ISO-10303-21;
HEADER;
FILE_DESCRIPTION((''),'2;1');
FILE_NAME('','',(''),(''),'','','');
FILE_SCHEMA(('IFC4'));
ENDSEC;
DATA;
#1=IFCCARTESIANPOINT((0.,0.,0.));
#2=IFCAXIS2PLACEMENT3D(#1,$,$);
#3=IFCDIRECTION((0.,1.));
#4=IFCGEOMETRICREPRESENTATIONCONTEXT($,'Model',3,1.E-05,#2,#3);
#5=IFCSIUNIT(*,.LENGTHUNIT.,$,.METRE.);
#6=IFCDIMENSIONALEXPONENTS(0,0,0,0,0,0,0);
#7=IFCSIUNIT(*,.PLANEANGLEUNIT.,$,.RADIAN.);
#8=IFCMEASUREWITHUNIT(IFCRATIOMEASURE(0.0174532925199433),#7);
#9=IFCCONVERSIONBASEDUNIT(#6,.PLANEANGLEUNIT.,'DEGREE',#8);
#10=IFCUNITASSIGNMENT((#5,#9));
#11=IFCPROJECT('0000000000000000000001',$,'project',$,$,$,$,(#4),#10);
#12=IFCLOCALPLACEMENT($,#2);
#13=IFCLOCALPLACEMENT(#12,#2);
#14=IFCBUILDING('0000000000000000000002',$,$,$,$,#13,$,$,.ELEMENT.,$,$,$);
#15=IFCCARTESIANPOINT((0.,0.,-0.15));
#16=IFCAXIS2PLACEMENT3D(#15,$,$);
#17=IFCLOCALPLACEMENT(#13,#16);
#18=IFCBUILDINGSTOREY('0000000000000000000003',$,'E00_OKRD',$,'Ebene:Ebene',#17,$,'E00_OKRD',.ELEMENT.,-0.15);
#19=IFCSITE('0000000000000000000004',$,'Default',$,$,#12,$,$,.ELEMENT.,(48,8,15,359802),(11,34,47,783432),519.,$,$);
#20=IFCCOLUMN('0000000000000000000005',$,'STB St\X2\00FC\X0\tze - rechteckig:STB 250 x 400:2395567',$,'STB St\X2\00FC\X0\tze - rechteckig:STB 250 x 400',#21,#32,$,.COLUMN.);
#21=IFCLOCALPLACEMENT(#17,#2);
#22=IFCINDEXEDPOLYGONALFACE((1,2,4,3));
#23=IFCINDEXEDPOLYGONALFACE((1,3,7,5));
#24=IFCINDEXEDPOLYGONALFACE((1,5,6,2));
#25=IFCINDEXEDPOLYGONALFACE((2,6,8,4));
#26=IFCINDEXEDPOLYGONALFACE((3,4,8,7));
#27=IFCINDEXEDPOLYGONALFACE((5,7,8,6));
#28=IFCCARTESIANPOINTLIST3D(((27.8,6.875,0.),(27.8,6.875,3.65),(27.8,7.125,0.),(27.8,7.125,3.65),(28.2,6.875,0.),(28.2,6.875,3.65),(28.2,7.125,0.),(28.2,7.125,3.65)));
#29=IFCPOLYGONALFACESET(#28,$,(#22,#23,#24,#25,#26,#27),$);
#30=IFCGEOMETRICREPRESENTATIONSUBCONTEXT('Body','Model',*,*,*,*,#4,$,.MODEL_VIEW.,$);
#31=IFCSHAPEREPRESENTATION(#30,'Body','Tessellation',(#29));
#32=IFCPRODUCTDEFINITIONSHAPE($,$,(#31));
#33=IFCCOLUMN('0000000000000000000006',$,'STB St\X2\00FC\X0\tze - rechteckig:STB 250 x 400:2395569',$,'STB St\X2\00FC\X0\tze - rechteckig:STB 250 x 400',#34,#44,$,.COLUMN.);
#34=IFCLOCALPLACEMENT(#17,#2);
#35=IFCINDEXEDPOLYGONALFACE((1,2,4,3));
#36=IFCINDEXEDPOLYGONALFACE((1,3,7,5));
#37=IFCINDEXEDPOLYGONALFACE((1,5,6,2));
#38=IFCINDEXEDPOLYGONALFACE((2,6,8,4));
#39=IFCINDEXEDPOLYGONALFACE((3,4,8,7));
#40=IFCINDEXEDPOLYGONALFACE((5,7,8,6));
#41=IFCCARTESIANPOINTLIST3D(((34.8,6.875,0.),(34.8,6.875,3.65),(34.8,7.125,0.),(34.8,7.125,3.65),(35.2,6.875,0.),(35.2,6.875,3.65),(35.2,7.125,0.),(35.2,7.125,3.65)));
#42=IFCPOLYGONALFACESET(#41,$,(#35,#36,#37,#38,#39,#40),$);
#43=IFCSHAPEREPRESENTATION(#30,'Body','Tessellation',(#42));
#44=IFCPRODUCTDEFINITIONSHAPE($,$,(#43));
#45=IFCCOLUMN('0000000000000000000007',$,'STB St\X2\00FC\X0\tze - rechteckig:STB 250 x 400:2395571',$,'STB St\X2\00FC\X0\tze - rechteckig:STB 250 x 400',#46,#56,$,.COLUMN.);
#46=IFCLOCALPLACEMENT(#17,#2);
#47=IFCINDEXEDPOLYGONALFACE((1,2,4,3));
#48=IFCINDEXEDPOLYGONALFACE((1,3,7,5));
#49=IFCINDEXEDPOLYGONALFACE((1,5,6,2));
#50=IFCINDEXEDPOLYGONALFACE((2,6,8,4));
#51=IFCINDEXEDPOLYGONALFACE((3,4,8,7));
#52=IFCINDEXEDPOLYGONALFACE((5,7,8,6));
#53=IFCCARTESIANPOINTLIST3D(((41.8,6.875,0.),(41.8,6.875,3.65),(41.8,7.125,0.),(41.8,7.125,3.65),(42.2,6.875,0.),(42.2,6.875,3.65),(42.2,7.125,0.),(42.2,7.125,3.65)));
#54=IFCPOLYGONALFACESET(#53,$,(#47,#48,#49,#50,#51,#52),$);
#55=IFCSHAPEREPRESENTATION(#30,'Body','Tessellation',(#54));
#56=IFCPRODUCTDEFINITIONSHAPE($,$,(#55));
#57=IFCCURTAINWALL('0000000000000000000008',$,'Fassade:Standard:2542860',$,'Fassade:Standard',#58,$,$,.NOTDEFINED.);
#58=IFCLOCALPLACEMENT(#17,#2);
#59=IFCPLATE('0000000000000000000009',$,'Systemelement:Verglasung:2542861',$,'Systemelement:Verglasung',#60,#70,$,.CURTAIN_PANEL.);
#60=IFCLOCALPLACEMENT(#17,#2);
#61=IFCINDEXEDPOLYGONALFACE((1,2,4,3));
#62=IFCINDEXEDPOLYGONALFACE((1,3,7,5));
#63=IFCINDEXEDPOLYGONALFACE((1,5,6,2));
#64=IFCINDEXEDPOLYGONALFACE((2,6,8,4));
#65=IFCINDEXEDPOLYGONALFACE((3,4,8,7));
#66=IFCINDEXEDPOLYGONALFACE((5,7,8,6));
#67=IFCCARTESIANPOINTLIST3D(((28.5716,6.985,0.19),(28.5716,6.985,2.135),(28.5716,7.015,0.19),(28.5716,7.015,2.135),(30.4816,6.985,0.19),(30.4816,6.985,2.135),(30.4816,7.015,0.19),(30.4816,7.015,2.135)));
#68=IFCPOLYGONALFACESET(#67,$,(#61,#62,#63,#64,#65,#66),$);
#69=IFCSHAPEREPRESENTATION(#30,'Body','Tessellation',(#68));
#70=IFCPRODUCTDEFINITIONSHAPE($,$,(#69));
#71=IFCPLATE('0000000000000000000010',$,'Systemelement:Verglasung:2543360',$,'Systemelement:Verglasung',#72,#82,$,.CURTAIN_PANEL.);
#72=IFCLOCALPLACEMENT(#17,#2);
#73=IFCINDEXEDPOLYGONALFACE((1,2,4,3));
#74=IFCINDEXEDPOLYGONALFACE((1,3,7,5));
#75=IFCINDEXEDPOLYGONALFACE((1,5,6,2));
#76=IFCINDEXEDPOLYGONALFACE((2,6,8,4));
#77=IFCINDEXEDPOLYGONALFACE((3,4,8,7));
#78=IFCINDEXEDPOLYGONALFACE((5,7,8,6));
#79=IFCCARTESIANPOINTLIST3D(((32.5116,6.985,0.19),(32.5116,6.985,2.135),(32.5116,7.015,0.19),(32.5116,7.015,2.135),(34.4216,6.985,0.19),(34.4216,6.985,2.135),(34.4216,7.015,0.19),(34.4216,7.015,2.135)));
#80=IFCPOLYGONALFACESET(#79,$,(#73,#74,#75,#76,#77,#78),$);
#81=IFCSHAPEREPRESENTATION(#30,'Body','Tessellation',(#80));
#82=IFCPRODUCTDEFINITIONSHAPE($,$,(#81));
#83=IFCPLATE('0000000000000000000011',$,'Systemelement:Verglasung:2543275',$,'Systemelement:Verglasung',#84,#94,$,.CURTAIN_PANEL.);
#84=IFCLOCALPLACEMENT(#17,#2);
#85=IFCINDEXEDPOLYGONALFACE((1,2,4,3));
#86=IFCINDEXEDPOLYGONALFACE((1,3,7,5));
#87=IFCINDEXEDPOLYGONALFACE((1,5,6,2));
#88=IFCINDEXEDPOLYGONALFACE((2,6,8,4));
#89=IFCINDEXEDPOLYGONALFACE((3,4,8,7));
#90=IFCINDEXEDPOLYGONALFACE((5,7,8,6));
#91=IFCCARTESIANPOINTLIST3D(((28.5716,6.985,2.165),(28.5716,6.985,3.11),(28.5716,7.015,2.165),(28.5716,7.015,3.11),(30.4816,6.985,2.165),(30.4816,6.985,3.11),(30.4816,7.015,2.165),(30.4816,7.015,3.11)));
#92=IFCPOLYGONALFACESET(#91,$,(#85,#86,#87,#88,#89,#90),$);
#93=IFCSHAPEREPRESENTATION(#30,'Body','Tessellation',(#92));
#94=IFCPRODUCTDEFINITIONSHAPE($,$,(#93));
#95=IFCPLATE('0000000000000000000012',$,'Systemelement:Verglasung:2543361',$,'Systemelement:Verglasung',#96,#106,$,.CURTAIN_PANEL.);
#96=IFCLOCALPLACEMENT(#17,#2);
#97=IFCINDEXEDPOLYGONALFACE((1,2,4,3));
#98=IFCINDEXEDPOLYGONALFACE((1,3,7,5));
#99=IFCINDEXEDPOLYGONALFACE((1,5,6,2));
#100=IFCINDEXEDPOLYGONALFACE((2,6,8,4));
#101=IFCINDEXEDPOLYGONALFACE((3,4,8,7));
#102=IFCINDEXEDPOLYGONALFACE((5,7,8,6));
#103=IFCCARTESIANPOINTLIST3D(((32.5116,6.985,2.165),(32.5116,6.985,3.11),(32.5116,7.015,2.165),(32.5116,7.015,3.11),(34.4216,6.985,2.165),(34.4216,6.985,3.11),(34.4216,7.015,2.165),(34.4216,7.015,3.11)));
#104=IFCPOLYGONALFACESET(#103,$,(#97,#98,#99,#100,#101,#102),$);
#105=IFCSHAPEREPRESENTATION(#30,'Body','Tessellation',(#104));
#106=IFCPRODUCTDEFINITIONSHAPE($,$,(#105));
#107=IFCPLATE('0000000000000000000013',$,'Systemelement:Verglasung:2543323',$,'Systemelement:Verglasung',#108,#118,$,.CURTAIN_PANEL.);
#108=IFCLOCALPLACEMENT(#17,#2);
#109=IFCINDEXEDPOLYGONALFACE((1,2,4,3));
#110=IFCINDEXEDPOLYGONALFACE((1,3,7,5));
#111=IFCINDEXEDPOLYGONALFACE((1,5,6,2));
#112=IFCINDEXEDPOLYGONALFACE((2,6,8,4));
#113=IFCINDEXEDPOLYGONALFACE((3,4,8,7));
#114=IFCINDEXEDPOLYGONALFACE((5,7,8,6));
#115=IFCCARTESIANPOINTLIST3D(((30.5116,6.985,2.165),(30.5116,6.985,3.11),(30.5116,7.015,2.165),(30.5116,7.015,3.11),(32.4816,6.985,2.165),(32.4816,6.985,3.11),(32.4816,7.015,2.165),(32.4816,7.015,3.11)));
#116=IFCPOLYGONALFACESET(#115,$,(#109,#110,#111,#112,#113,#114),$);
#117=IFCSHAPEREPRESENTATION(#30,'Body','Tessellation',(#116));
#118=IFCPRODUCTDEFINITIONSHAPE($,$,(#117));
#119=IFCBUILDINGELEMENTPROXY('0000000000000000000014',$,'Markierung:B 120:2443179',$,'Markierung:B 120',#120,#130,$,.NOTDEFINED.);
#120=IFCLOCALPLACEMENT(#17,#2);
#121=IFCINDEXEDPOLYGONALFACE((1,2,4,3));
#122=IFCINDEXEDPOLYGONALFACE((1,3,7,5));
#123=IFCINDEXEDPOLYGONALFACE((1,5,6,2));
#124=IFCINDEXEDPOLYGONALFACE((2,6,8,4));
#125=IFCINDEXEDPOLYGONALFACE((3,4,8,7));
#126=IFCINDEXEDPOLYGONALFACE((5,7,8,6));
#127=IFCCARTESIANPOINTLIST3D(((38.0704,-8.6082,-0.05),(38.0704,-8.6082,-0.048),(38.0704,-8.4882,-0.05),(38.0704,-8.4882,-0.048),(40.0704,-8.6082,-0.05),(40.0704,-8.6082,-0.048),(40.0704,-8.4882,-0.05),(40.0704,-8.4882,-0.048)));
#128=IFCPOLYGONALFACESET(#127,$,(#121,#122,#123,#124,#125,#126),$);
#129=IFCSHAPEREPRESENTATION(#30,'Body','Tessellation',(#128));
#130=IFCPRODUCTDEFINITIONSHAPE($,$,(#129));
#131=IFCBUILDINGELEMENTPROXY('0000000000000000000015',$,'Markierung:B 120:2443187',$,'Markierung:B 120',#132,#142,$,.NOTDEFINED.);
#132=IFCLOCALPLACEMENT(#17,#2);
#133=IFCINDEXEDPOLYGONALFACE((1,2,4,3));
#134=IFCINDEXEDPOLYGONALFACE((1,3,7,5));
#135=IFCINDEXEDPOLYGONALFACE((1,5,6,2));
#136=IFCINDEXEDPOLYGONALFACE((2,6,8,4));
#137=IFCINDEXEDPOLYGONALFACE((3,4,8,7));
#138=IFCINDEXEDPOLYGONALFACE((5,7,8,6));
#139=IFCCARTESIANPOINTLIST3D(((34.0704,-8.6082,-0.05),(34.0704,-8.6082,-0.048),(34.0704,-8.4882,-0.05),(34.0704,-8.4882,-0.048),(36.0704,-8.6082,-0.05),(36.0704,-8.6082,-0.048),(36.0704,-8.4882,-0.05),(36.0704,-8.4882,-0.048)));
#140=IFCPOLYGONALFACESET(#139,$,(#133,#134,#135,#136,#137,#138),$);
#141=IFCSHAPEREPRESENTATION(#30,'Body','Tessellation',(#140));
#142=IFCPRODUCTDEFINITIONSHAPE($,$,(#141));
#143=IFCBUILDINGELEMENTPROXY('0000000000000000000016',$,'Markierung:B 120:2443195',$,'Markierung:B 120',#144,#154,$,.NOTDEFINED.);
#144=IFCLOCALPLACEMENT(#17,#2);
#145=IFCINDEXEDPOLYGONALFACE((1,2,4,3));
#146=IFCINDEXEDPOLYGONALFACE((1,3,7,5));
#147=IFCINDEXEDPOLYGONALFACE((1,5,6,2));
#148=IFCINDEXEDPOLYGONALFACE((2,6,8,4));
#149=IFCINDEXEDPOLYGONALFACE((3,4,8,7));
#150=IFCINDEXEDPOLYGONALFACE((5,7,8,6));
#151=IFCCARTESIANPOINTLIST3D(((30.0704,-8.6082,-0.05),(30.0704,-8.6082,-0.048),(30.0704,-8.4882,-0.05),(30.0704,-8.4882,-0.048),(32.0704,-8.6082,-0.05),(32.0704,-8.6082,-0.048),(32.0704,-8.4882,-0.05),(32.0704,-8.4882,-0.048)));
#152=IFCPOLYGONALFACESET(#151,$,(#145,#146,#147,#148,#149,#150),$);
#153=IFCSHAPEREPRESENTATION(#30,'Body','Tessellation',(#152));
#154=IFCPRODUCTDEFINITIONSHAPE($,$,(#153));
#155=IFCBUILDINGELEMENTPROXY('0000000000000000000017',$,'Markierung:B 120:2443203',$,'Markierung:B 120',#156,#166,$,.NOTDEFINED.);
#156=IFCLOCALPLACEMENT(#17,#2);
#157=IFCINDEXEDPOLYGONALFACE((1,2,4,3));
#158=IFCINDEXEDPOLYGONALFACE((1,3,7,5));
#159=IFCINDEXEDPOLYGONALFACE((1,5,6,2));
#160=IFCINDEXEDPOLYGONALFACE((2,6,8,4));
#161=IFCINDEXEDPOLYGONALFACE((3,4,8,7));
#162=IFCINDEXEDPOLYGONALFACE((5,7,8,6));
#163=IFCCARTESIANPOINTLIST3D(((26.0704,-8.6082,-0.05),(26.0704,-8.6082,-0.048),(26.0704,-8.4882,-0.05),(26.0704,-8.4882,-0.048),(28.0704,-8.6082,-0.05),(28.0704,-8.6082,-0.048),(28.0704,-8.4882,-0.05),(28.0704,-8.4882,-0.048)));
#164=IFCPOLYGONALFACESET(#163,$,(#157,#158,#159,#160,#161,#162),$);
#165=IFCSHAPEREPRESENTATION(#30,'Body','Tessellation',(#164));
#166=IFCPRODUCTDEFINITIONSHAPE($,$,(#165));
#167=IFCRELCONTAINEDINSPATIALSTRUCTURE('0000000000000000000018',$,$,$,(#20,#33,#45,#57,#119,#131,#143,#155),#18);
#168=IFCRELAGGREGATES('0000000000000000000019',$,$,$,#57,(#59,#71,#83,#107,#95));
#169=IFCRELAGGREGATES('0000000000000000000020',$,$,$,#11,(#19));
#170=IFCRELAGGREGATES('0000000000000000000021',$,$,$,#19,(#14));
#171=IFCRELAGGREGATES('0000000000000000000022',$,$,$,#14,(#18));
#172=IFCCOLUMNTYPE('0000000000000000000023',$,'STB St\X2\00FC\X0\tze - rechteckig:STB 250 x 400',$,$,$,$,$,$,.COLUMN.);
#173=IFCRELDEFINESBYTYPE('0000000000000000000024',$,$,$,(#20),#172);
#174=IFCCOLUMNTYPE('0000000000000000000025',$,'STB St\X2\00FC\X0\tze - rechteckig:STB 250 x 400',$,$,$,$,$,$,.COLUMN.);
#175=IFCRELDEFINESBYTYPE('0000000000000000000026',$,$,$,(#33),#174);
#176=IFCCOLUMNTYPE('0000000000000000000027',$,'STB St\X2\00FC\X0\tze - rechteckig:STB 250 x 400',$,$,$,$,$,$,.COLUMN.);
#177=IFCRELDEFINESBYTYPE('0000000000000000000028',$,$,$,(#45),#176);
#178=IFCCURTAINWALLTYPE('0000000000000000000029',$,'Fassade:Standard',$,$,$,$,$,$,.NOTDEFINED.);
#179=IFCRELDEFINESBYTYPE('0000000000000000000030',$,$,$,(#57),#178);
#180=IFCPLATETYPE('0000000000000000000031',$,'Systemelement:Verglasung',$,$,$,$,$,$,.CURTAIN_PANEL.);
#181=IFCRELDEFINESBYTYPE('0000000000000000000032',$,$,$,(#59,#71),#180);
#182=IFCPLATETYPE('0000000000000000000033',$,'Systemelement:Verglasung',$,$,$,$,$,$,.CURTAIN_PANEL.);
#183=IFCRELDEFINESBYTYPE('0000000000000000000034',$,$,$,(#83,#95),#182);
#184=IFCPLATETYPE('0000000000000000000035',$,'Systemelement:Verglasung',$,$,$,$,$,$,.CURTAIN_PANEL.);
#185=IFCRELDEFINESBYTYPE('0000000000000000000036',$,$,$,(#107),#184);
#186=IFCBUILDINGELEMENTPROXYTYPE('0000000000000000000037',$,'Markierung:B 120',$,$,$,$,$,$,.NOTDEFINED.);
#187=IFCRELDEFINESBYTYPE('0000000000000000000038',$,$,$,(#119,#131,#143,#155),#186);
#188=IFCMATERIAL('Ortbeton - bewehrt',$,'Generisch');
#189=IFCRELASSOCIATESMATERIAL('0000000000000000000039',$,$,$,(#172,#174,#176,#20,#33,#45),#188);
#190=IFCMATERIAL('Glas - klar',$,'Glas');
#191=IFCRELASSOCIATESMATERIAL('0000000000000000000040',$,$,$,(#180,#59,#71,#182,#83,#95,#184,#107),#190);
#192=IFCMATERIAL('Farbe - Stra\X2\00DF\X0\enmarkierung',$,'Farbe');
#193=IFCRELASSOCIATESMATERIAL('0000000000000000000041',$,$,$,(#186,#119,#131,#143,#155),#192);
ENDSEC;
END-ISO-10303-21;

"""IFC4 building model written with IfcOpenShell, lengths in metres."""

from ifc_helpers import new_model, entity, si_unit, converted_unit, direction, frame, frame_2d, origin, origin_2d_with_axis, place, context, subcontext, project, spatial, rectangle, extrude, shape, source, transform, mapped, material, material_profile, profile_set, profile_usage, type_object, type_shapes, element, aggregate, save


model = new_model("IFC4")

# Units and contexts
model_context = context("Model", 3, precision=1e-05, world=origin(), true_north=direction((0.0, 1.0)))
body_context = subcontext(model_context, "Body", "Model", "MODEL_VIEW")
footprint_context = subcontext(model_context, "FootPrint", "Model", "MODEL_VIEW")
ifc_project = project(units=[si_unit("LENGTHUNIT", "METRE"), converted_unit("PLANEANGLEUNIT", "DEGREE", entity("IfcRatioMeasure", 0.0174532925199433), si_unit("PLANEANGLEUNIT", "RADIAN"), dimensions=[0, 0, 0, 0, 0, 0, 0])], contexts=[model_context])

# Site, building, storey
site_placement = place(None, frame((0.0, 0.0, 0.0)))
site = spatial("IfcSite", under=ifc_project, at=site_placement, Name="Default", CompositionType="ELEMENT", RefLatitude=(48, 8, 15, 359802), RefLongitude=(11, 34, 47, 783432), RefElevation=519.0)
building_placement = place(site_placement, origin())
building = spatial("IfcBuilding", under=site, at=building_placement, CompositionType="ELEMENT")
storey_placement = place(building_placement, frame((0.0, 0.0, -0.15)))
storey = spatial("IfcBuildingStorey", under=building, at=storey_placement, Name="E00_OKRD", ObjectType="Ebene:Ebene", LongName="E00_OKRD", CompositionType="ELEMENT", Elevation=-0.15)

# Columns
ifc_material_1 = material(Name="Ortbeton - bewehrt", Category="Generisch")
ifc_material_profile_1 = material_profile(ifc_material_1, rectangle(XDim=0.4, YDim=0.25, at=frame_2d((0.0, 0.0), x_axis=(1.0, 0.0))), Name="STB 250 x 400")
ifc_profile_set_1 = profile_set([ifc_material_profile_1], Name="STB 250 x 400")
ifc_profile_usage_1 = profile_usage(ifc_profile_set_1)
column_type_1 = type_object("IfcColumnType", Name="STB Stütze - rechteckig:STB 250 x 400", PredefinedType="COLUMN", material=ifc_profile_set_1)
shared_shape_1 = source(origin(), body_context, "Body", "SweptSolid", [
    extrude(rectangle(XDim=0.4, YDim=0.25, at=frame_2d((0.0, 0.0), x_axis=(1.0, 0.0))), frame((0.2, 0.125, 0.0), z_axis=(0.0, 0.0, 1.0), x_axis=(-1.0, 0.0, 0.0)), (0.0, 0.0, 1.0), 3.65),
])
type_shapes(column_type_1, [shared_shape_1])
column_1_placement = place(storey_placement, frame((27.8, 6.875, 0.0)))
element("IfcColumn", 1, at=column_1_placement, inside=storey, type_object=column_type_1, material=ifc_profile_usage_1, Name="STB Stütze - rechteckig:STB 250 x 400:2395567", ObjectType="STB Stütze - rechteckig:STB 250 x 400", PredefinedType="COLUMN", context=body_context, shape_type="MappedRepresentation", body=[
    mapped(shared_shape_1, transform((0.0, 0.0, 0.0), scale=1.0)),
])
ifc_profile_usage_2 = profile_usage(ifc_profile_set_1)
column_type_2 = type_object("IfcColumnType", Name="STB Stütze - rechteckig:STB 250 x 400", PredefinedType="COLUMN", material=ifc_profile_set_1)
shared_shape_2 = source(origin(), body_context, "Body", "SweptSolid", [
    extrude(rectangle(XDim=0.4, YDim=0.25, at=frame_2d((0.0, 0.0), x_axis=(1.0, 0.0))), frame((0.2, 0.125, 0.0), z_axis=(0.0, 0.0, 1.0), x_axis=(-1.0, 0.0, 0.0)), (0.0, 0.0, 1.0), 3.65),
])
type_shapes(column_type_2, [shared_shape_2])
column_2_placement = place(storey_placement, frame((34.8, 6.875, 0.0)))
element("IfcColumn", 2, at=column_2_placement, inside=storey, type_object=column_type_2, material=ifc_profile_usage_2, Name="STB Stütze - rechteckig:STB 250 x 400:2395569", ObjectType="STB Stütze - rechteckig:STB 250 x 400", PredefinedType="COLUMN", context=body_context, shape_type="MappedRepresentation", body=[
    mapped(shared_shape_2, transform((0.0, 0.0, 0.0), scale=1.0)),
])
ifc_profile_usage_3 = profile_usage(ifc_profile_set_1)
column_type_3 = type_object("IfcColumnType", Name="STB Stütze - rechteckig:STB 250 x 400", PredefinedType="COLUMN", material=ifc_profile_set_1)
shared_shape_3 = source(origin(), body_context, "Body", "SweptSolid", [
    extrude(rectangle(XDim=0.4, YDim=0.25, at=frame_2d((0.0, 0.0), x_axis=(1.0, 0.0))), frame((0.2, 0.125, 0.0), z_axis=(0.0, 0.0, 1.0), x_axis=(-1.0, 0.0, 0.0)), (0.0, 0.0, 1.0), 3.65),
])
type_shapes(column_type_3, [shared_shape_3])
column_3_placement = place(storey_placement, frame((41.8, 6.875, 0.0)))
element("IfcColumn", 3, at=column_3_placement, inside=storey, type_object=column_type_3, material=ifc_profile_usage_3, Name="STB Stütze - rechteckig:STB 250 x 400:2395571", ObjectType="STB Stütze - rechteckig:STB 250 x 400", PredefinedType="COLUMN", context=body_context, shape_type="MappedRepresentation", body=[
    mapped(shared_shape_3, transform((0.0, 0.0, 0.0), scale=1.0)),
])

# Curtain wall, plates
curtain_wall_type = type_object("IfcCurtainWallType", Name="Fassade:Standard", PredefinedType="NOTDEFINED")
curtain_wall_placement = place(storey_placement, frame((0.0, 0.0, 0.15)))
curtain_wall = element("IfcCurtainWall", 4, at=curtain_wall_placement, inside=storey, type_object=curtain_wall_type, Name="Fassade:Standard:2542860", ObjectType="Fassade:Standard", PredefinedType="NOTDEFINED")
ifc_material_2 = material(Name="Glas - klar", Category="Glas")
plate_type_1 = type_object("IfcPlateType", Name="Systemelement:Verglasung", PredefinedType="CURTAIN_PANEL", material=ifc_material_2)
shared_shape_4 = source(origin(), body_context, "Body", "SweptSolid", [
    extrude(rectangle(XDim=0.03, YDim=1.91, at=origin_2d_with_axis()), frame((0.0, 0.0, 0.0), z_axis=(0.0, 0.0, 1.0), x_axis=(0.0, 1.0, 0.0)), (0.0, 0.0, 1.0), 1.945),
])
cartesian_point_1 = entity("IfcCartesianPoint", [0.955, -0.015])
shared_shape_5 = source(origin(), footprint_context, "FootPrint", "Curve2D", [
    entity("IfcPolyline", [cartesian_point_1, entity("IfcCartesianPoint", [0.955, 0.015]), entity("IfcCartesianPoint", [-0.955, 0.015]), entity("IfcCartesianPoint", [-0.955, -0.015]), cartesian_point_1]),
])
type_shapes(plate_type_1, [shared_shape_4, shared_shape_5])
plate_1_placement = place(curtain_wall_placement, frame((29.5266, 7.0, 0.04)))
plate_1 = element("IfcPlate", 5, at=plate_1_placement, type_object=plate_type_1, material=ifc_material_2, Name="Systemelement:Verglasung:2542861", ObjectType="Systemelement:Verglasung", PredefinedType="CURTAIN_PANEL", shapes=[
    shape(body_context, "Body", "MappedRepresentation", [mapped(shared_shape_4, transform((0.0, 0.0, 0.0), scale=1.0))]),
    shape(body_context, "Body", "MappedRepresentation", [mapped(shared_shape_5, transform((0.0, 0.0, 0.0), scale=1.0))]),
])
plate_2_placement = place(curtain_wall_placement, frame((33.4666, 7.0, 0.04)))
plate_2 = element("IfcPlate", 6, at=plate_2_placement, type_object=plate_type_1, material=ifc_material_2, Name="Systemelement:Verglasung:2543360", ObjectType="Systemelement:Verglasung", PredefinedType="CURTAIN_PANEL", shapes=[
    shape(body_context, "Body", "MappedRepresentation", [mapped(shared_shape_4, transform((0.0, 0.0, 0.0), scale=1.0))]),
    shape(body_context, "Body", "MappedRepresentation", [mapped(shared_shape_5, transform((0.0, 0.0, 0.0), scale=1.0))]),
])
plate_type_2 = type_object("IfcPlateType", Name="Systemelement:Verglasung", PredefinedType="CURTAIN_PANEL", material=ifc_material_2)
shared_shape_6 = source(origin(), body_context, "Body", "SweptSolid", [
    extrude(rectangle(XDim=0.03, YDim=1.91, at=origin_2d_with_axis()), frame((0.0, 0.0, 0.0), z_axis=(0.0, 0.0, 1.0), x_axis=(0.0, 1.0, 0.0)), (0.0, 0.0, 1.0), 0.945),
])
cartesian_point_2 = entity("IfcCartesianPoint", [0.955, -0.015])
shared_shape_7 = source(origin(), footprint_context, "FootPrint", "Curve2D", [
    entity("IfcPolyline", [cartesian_point_2, entity("IfcCartesianPoint", [0.955, 0.015]), entity("IfcCartesianPoint", [-0.955, 0.015]), entity("IfcCartesianPoint", [-0.955, -0.015]), cartesian_point_2]),
])
type_shapes(plate_type_2, [shared_shape_6, shared_shape_7])
plate_3_placement = place(curtain_wall_placement, frame((29.5266, 7.0, 2.015)))
plate_3 = element("IfcPlate", 7, at=plate_3_placement, type_object=plate_type_2, material=ifc_material_2, Name="Systemelement:Verglasung:2543275", ObjectType="Systemelement:Verglasung", PredefinedType="CURTAIN_PANEL", shapes=[
    shape(body_context, "Body", "MappedRepresentation", [mapped(shared_shape_6, transform((0.0, 0.0, 0.0), scale=1.0))]),
    shape(body_context, "Body", "MappedRepresentation", [mapped(shared_shape_7, transform((0.0, 0.0, 0.0), scale=1.0))]),
])
plate_4_placement = place(curtain_wall_placement, frame((33.4666, 7.0, 2.015)))
plate_4 = element("IfcPlate", 8, at=plate_4_placement, type_object=plate_type_2, material=ifc_material_2, Name="Systemelement:Verglasung:2543361", ObjectType="Systemelement:Verglasung", PredefinedType="CURTAIN_PANEL", shapes=[
    shape(body_context, "Body", "MappedRepresentation", [mapped(shared_shape_6, transform((0.0, 0.0, 0.0), scale=1.0))]),
    shape(body_context, "Body", "MappedRepresentation", [mapped(shared_shape_7, transform((0.0, 0.0, 0.0), scale=1.0))]),
])
plate_type_3 = type_object("IfcPlateType", Name="Systemelement:Verglasung", PredefinedType="CURTAIN_PANEL", material=ifc_material_2)
shared_shape_8 = source(origin(), body_context, "Body", "SweptSolid", [
    extrude(rectangle(XDim=0.945, YDim=1.97, at=frame_2d((0.0, 0.0), x_axis=(1.0, 0.0))), frame((0.0, -0.015, 0.4725), z_axis=(0.0, 1.0, 0.0), x_axis=(0.0, 0.0, 1.0)), (0.0, 0.0, 1.0), 0.03),
])
cartesian_point_3 = entity("IfcCartesianPoint", [-0.985, -0.015])
shared_shape_9 = source(origin(), footprint_context, "FootPrint", "Curve2D", [
    entity("IfcPolyline", [cartesian_point_3, entity("IfcCartesianPoint", [-0.985, -0.015]), entity("IfcCartesianPoint", [0.0, -0.015]), entity("IfcCartesianPoint", [0.985, -0.015]), entity("IfcCartesianPoint", [0.985, -0.015]), entity("IfcCartesianPoint", [0.0, -0.015]), cartesian_point_3]),
])
type_shapes(plate_type_3, [shared_shape_8, shared_shape_9])
plate_5_placement = place(curtain_wall_placement, frame((31.4966, 7.0, 2.015)))
plate_5 = element("IfcPlate", 9, at=plate_5_placement, type_object=plate_type_3, material=ifc_material_2, Name="Systemelement:Verglasung:2543323", ObjectType="Systemelement:Verglasung", PredefinedType="CURTAIN_PANEL", shapes=[
    shape(body_context, "Body", "MappedRepresentation", [mapped(shared_shape_8, transform((0.0, 0.0, 0.0), scale=1.0))]),
    shape(body_context, "Body", "MappedRepresentation", [mapped(shared_shape_9, transform((0.0, 0.0, 0.0), scale=1.0))]),
])
aggregate(curtain_wall, [plate_1, plate_2, plate_3, plate_5, plate_4])

# Building element proxies
ifc_material_3 = material(Name="Farbe - Straßenmarkierung", Category="Farbe")
building_element_proxy_type = type_object("IfcBuildingElementProxyType", Name="Markierung:B 120", PredefinedType="NOTDEFINED", material=ifc_material_3)
shared_shape_10 = source(origin(), body_context, "Body", "SweptSolid", [
    extrude(rectangle(XDim=0.12, YDim=2.0, at=frame_2d((0.0, 0.0), x_axis=(1.0, 0.0))), frame((0.06, 1.0, 0.0), z_axis=(0.0, 0.0, 1.0), x_axis=(-1.0, 0.0, 0.0)), (0.0, 0.0, 1.0), 0.002),
])
type_shapes(building_element_proxy_type, [shared_shape_10])
for number, where, z_axis, x_axis, name in (
    (10, (40.0704, -8.6082, -0.05), (0.0, 0.0, 1.0), (0.0, 1.0, 0.0), "Markierung:B 120:2443179"),
    (11, (36.0704, -8.6082, -0.05), (0.0, 0.0, 1.0), (0.0, 1.0, 0.0), "Markierung:B 120:2443187"),
    (12, (32.0704, -8.6082, -0.05), (0.0, 0.0, 1.0), (0.0, 1.0, 0.0), "Markierung:B 120:2443195"),
    (13, (28.0704, -8.6082, -0.05), (0.0, 0.0, 1.0), (0.0, 1.0, 0.0), "Markierung:B 120:2443203"),
):
    element("IfcBuildingElementProxy", number, at=place(storey_placement, frame(where, z_axis=z_axis, x_axis=x_axis)), inside=storey, type_object=building_element_proxy_type, material=ifc_material_3, Name=name, ObjectType="Markierung:B 120", PredefinedType="NOTDEFINED", context=body_context, shape_type="MappedRepresentation", body=[
        mapped(shared_shape_10, transform((0.0, 0.0, 0.0), scale=1.0)),
    ])

save(model, "model.ifc")
